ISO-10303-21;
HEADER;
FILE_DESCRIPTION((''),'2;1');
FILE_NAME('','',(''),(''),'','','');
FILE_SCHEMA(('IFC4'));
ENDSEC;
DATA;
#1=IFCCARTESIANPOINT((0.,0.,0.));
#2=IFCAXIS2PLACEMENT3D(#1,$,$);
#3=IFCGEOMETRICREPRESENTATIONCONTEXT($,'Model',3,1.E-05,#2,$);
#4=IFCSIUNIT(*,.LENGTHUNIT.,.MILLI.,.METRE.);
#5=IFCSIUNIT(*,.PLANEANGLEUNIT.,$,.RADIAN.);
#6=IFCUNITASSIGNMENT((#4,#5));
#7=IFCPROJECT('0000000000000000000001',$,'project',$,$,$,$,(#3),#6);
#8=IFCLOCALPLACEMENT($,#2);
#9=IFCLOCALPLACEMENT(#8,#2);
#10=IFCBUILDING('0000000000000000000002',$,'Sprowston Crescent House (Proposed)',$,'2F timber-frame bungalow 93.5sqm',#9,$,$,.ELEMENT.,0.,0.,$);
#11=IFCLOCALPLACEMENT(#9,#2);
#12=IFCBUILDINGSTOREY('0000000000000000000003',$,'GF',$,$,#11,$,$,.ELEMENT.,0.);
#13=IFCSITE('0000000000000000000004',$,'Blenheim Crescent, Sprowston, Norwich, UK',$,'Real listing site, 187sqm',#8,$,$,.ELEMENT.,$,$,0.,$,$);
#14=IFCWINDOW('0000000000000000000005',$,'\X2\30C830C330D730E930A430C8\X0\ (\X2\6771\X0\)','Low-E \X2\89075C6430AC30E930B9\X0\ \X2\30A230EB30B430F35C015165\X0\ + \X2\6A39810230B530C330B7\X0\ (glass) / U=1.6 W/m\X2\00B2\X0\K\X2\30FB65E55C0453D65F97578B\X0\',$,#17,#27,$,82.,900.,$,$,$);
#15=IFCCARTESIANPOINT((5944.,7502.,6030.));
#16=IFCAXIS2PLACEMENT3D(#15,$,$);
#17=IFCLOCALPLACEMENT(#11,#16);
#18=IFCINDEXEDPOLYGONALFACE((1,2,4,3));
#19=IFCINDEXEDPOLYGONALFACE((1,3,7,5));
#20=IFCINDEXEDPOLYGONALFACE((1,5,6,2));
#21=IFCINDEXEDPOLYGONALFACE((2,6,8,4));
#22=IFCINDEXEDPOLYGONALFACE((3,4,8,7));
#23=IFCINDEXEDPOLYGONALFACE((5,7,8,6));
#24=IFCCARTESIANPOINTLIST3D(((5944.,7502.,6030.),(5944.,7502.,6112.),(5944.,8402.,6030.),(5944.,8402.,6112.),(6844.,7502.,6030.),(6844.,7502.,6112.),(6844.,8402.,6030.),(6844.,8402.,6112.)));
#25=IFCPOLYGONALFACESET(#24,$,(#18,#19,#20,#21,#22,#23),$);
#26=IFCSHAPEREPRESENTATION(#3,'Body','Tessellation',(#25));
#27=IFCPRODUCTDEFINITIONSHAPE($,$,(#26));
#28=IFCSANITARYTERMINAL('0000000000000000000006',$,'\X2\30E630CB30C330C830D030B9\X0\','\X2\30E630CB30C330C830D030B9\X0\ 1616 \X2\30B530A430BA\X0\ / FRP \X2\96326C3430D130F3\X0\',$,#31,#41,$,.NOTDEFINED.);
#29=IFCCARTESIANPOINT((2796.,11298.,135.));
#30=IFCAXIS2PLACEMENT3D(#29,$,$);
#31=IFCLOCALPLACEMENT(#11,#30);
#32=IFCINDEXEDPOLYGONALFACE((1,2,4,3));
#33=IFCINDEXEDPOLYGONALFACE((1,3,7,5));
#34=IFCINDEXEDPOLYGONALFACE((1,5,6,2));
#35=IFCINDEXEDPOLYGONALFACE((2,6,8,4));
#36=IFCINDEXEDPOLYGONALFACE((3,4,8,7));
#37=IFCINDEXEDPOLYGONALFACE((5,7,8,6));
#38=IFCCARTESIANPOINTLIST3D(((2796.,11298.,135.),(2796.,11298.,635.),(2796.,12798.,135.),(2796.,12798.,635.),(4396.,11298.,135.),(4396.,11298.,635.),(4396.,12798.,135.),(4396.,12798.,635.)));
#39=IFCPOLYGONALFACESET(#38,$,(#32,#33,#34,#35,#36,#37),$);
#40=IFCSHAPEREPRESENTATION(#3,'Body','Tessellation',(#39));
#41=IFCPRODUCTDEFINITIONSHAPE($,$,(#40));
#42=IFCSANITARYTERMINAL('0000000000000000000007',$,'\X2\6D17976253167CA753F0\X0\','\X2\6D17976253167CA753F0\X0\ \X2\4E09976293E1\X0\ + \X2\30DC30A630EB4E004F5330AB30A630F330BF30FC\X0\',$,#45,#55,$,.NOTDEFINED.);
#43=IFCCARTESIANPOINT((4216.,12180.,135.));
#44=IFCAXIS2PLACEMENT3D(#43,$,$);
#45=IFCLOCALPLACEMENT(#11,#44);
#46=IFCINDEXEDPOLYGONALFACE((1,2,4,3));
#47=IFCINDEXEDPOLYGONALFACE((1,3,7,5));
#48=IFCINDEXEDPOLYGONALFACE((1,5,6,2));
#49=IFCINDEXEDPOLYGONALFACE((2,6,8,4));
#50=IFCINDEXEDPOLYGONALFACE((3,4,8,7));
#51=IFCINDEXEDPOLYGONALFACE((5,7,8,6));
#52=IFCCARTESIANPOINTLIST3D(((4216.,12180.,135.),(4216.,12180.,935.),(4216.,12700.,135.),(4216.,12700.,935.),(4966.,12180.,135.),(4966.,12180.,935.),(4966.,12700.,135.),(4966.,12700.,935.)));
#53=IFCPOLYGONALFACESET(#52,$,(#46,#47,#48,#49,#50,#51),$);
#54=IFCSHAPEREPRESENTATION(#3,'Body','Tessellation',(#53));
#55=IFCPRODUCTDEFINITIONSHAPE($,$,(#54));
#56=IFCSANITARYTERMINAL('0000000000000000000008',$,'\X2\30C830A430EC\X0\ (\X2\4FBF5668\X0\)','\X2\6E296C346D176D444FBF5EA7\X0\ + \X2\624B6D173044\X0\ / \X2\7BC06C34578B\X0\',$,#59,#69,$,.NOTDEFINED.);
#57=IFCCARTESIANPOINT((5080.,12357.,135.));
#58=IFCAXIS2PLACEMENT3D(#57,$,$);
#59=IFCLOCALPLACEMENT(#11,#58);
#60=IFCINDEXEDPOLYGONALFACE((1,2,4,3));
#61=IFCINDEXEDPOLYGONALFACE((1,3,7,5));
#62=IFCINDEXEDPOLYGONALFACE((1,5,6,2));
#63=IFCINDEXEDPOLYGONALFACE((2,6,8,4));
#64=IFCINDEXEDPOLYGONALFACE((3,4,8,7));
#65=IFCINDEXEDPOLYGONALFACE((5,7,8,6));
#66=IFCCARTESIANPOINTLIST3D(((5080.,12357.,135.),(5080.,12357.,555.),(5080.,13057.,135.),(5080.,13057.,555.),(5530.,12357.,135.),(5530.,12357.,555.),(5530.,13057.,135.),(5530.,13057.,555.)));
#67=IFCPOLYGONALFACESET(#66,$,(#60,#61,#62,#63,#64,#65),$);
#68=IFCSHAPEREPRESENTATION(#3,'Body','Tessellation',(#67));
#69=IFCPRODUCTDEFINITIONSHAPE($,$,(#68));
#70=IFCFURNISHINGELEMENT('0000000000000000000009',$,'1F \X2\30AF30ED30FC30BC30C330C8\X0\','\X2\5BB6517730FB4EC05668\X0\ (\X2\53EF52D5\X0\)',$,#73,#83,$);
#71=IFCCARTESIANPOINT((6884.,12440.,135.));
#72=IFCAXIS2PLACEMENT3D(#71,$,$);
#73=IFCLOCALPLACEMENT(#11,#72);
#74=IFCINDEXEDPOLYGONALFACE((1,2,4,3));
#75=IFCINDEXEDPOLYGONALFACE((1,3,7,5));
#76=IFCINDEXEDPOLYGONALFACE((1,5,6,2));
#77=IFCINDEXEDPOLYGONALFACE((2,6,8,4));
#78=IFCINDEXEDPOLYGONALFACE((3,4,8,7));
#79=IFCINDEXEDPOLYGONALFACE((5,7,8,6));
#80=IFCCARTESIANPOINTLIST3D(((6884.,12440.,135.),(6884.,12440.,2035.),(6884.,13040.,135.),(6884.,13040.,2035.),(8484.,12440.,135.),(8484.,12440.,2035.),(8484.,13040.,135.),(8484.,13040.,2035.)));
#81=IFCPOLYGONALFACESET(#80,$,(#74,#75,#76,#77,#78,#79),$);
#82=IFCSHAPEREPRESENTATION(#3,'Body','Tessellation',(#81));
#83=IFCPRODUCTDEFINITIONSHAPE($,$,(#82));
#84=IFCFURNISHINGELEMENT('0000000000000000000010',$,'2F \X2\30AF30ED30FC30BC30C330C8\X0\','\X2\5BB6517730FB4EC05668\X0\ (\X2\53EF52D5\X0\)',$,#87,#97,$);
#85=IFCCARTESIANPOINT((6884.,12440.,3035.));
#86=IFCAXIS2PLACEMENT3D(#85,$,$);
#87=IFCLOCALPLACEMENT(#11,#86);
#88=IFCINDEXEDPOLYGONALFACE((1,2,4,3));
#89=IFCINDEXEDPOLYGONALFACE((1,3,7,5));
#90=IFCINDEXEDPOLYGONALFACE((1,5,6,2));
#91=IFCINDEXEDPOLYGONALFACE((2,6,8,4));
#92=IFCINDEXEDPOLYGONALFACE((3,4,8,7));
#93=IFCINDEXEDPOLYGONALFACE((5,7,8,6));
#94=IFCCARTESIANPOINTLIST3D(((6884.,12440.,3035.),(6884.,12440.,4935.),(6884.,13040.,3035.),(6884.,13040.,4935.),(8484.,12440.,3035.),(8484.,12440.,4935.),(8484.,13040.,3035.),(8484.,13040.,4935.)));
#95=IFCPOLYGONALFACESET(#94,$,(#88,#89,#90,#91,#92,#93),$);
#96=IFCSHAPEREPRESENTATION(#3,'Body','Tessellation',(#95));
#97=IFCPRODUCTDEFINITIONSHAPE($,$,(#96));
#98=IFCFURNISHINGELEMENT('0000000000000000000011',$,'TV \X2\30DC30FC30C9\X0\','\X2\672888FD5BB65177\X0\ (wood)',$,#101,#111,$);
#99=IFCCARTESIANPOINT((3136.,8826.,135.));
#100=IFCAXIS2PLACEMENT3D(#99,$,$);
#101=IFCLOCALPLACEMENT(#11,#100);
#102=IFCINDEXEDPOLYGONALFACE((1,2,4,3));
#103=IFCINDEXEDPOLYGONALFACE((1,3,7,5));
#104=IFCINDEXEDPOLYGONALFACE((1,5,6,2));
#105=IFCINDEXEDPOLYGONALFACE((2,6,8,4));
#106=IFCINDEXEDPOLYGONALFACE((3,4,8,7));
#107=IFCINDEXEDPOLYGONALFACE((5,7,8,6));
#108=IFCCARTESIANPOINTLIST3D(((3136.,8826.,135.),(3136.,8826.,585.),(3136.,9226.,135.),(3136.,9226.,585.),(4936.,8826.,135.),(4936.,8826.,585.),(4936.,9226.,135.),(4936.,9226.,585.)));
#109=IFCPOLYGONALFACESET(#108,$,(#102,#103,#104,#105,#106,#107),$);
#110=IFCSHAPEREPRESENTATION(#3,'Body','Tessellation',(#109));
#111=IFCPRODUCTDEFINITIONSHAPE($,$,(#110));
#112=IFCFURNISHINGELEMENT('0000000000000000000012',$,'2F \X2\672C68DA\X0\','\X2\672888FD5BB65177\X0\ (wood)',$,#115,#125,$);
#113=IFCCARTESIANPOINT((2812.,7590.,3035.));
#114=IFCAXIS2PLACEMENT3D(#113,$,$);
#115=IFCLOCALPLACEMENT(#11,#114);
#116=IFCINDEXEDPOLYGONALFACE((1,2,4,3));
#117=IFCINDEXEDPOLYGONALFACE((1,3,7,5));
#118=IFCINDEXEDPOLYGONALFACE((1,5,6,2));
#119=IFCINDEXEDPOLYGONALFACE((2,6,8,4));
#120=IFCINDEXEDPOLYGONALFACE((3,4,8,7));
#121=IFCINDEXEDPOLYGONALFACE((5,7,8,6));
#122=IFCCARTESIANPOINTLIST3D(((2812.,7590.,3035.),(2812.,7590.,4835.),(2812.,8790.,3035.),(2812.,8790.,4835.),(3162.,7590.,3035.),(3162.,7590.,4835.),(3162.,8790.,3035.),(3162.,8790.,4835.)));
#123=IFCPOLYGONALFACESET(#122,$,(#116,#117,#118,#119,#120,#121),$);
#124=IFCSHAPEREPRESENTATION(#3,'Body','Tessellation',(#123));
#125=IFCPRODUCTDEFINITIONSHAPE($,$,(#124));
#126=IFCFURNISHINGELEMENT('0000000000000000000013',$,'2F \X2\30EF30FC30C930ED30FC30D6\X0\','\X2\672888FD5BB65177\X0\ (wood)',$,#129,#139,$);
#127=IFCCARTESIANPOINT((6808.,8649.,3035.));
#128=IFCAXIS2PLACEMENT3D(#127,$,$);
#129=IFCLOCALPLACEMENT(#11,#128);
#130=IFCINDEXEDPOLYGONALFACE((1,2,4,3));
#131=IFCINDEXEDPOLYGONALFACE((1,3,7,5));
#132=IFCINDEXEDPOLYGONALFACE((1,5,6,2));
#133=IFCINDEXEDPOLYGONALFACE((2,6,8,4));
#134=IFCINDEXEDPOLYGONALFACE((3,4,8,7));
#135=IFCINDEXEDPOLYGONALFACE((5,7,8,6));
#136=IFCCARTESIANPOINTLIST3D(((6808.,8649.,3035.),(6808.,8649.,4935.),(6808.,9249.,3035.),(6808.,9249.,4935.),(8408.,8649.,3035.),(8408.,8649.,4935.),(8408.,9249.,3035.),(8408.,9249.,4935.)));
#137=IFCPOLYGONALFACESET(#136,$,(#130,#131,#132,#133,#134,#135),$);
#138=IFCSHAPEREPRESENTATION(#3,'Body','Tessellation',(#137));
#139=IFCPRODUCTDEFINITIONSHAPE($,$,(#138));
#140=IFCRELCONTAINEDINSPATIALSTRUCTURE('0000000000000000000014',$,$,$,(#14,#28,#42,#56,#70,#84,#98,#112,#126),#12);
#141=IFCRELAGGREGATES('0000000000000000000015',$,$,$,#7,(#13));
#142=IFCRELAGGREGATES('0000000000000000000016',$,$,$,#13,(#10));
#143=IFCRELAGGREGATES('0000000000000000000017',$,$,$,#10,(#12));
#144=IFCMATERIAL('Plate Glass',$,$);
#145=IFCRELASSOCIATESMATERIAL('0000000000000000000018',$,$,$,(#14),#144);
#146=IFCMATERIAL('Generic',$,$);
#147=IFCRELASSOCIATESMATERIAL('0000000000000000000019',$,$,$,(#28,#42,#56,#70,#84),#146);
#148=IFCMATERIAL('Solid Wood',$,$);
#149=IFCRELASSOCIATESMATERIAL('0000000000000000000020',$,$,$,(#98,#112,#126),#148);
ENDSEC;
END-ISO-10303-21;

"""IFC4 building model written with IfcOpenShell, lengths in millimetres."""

from ifc_helpers import new_model, si_unit, frame, frame_2d, origin, place, context, project, spatial, rectangle, extrude, material, element, save


model = new_model("IFC4")

# Units and contexts
model_context = context("Model", 3, precision=1e-05, world=origin())
ifc_project = project(units=[si_unit("LENGTHUNIT", "METRE", prefix="MILLI"), si_unit("PLANEANGLEUNIT", "RADIAN")], contexts=[model_context])

# Site, building, storey
site_placement = place(None, origin())
site = spatial("IfcSite", under=ifc_project, at=site_placement, Name="Blenheim Crescent, Sprowston, Norwich, UK", ObjectType="Real listing site, 187sqm", CompositionType="ELEMENT", RefElevation=0.0)
building_placement = place(site_placement, origin())
building = spatial("IfcBuilding", under=site, at=building_placement, Name="Sprowston Crescent House (Proposed)", ObjectType="2F timber-frame bungalow 93.5sqm", CompositionType="ELEMENT", ElevationOfRefHeight=0.0, ElevationOfTerrain=0.0)
storey_placement = place(building_placement, origin())
storey = spatial("IfcBuildingStorey", under=building, at=storey_placement, Name="GF", CompositionType="ELEMENT", Elevation=0.0)

# Shared definitions
ifc_material_1 = material(Name="Solid Wood")
ifc_material_2 = material(Name="Plate Glass")

# Window
window_1_placement = place(storey_placement, frame((5944.0, 7502.0, 6030.0)))
element("IfcWindow", 1, at=window_1_placement, inside=storey, material=ifc_material_2, Name="トップライト (東)", Description="Low-E 複層ガラス アルゴン封入 + 樹脂サッシ (glass) / U=1.6 W/m²K・日射取得型", OverallHeight=82.0, OverallWidth=900.0, context=model_context, shape_type="SweptSolid", body=[
    extrude(rectangle(XDim=900.0, YDim=900.0, at=frame_2d((450.0, 450.0))), frame((5944.0, 7502.0, 6030.0)), (0.0, 0.0, 1.0), 82.0),
])

# Sanitary terminals
ifc_material_3 = material(Name="Generic")
sanitary_terminal_1_placement = place(storey_placement, frame((2796.0, 11298.0, 135.0)))
element("IfcSanitaryTerminal", 2, at=sanitary_terminal_1_placement, inside=storey, material=ifc_material_3, Name="ユニットバス", Description="ユニットバス 1616 サイズ / FRP 防水パン", PredefinedType="NOTDEFINED", context=model_context, shape_type="SweptSolid", body=[
    extrude(rectangle(XDim=1600.0, YDim=1500.0, at=frame_2d((800.0, 750.0))), frame((2796.0, 11298.0, 135.0)), (0.0, 0.0, 1.0), 500.0),
])
sanitary_terminal_2_placement = place(storey_placement, frame((4216.0, 12180.0, 135.0)))
element("IfcSanitaryTerminal", 3, at=sanitary_terminal_2_placement, inside=storey, material=ifc_material_3, Name="洗面化粧台", Description="洗面化粧台 三面鏡 + ボウル一体カウンター", PredefinedType="NOTDEFINED", context=model_context, shape_type="SweptSolid", body=[
    extrude(rectangle(XDim=750.0, YDim=520.0, at=frame_2d((375.0, 260.0))), frame((4216.0, 12180.0, 135.0)), (0.0, 0.0, 1.0), 800.0),
])
sanitary_terminal_3_placement = place(storey_placement, frame((5080.0, 12357.0, 135.0)))
element("IfcSanitaryTerminal", 4, at=sanitary_terminal_3_placement, inside=storey, material=ifc_material_3, Name="トイレ (便器)", Description="温水洗浄便座 + 手洗い / 節水型", PredefinedType="NOTDEFINED", context=model_context, shape_type="SweptSolid", body=[
    extrude(rectangle(XDim=450.0, YDim=700.0, at=frame_2d((225.0, 350.0))), frame((5080.0, 12357.0, 135.0)), (0.0, 0.0, 1.0), 420.0),
])

# Furnishing elements
furnishing_1_placement = place(storey_placement, frame((6884.0, 12440.0, 135.0)))
element("IfcFurnishingElement", 5, at=furnishing_1_placement, inside=storey, material=ifc_material_3, Name="1F クローゼット", Description="家具・什器 (可動)", context=model_context, shape_type="SweptSolid", body=[
    extrude(rectangle(XDim=1600.0, YDim=600.0, at=frame_2d((800.0, 300.0))), frame((6884.0, 12440.0, 135.0)), (0.0, 0.0, 1.0), 1900.0),
])
furnishing_2_placement = place(storey_placement, frame((6884.0, 12440.0, 3035.0)))
element("IfcFurnishingElement", 6, at=furnishing_2_placement, inside=storey, material=ifc_material_3, Name="2F クローゼット", Description="家具・什器 (可動)", context=model_context, shape_type="SweptSolid", body=[
    extrude(rectangle(XDim=1600.0, YDim=600.0, at=frame_2d((800.0, 300.0))), frame((6884.0, 12440.0, 3035.0)), (0.0, 0.0, 1.0), 1900.0),
])
furnishing_3_placement = place(storey_placement, frame((3136.0, 8826.0, 135.0)))
element("IfcFurnishingElement", 7, at=furnishing_3_placement, inside=storey, material=ifc_material_1, Name="TV ボード", Description="木製家具 (wood)", context=model_context, shape_type="SweptSolid", body=[
    extrude(rectangle(XDim=1800.0, YDim=400.0, at=frame_2d((900.0, 200.0))), frame((3136.0, 8826.0, 135.0)), (0.0, 0.0, 1.0), 450.0),
])
furnishing_4_placement = place(storey_placement, frame((2812.0, 7590.0, 3035.0)))
element("IfcFurnishingElement", 8, at=furnishing_4_placement, inside=storey, material=ifc_material_1, Name="2F 本棚", Description="木製家具 (wood)", context=model_context, shape_type="SweptSolid", body=[
    extrude(rectangle(XDim=350.0, YDim=1200.0, at=frame_2d((175.0, 600.0))), frame((2812.0, 7590.0, 3035.0)), (0.0, 0.0, 1.0), 1800.0),
])
furnishing_5_placement = place(storey_placement, frame((6808.0, 8649.0, 3035.0)))
element("IfcFurnishingElement", 9, at=furnishing_5_placement, inside=storey, material=ifc_material_1, Name="2F ワードローブ", Description="木製家具 (wood)", context=model_context, shape_type="SweptSolid", body=[
    extrude(rectangle(XDim=1600.0, YDim=600.0, at=frame_2d((800.0, 300.0))), frame((6808.0, 8649.0, 3035.0)), (0.0, 0.0, 1.0), 1900.0),
])

save(model, "model.ifc")
